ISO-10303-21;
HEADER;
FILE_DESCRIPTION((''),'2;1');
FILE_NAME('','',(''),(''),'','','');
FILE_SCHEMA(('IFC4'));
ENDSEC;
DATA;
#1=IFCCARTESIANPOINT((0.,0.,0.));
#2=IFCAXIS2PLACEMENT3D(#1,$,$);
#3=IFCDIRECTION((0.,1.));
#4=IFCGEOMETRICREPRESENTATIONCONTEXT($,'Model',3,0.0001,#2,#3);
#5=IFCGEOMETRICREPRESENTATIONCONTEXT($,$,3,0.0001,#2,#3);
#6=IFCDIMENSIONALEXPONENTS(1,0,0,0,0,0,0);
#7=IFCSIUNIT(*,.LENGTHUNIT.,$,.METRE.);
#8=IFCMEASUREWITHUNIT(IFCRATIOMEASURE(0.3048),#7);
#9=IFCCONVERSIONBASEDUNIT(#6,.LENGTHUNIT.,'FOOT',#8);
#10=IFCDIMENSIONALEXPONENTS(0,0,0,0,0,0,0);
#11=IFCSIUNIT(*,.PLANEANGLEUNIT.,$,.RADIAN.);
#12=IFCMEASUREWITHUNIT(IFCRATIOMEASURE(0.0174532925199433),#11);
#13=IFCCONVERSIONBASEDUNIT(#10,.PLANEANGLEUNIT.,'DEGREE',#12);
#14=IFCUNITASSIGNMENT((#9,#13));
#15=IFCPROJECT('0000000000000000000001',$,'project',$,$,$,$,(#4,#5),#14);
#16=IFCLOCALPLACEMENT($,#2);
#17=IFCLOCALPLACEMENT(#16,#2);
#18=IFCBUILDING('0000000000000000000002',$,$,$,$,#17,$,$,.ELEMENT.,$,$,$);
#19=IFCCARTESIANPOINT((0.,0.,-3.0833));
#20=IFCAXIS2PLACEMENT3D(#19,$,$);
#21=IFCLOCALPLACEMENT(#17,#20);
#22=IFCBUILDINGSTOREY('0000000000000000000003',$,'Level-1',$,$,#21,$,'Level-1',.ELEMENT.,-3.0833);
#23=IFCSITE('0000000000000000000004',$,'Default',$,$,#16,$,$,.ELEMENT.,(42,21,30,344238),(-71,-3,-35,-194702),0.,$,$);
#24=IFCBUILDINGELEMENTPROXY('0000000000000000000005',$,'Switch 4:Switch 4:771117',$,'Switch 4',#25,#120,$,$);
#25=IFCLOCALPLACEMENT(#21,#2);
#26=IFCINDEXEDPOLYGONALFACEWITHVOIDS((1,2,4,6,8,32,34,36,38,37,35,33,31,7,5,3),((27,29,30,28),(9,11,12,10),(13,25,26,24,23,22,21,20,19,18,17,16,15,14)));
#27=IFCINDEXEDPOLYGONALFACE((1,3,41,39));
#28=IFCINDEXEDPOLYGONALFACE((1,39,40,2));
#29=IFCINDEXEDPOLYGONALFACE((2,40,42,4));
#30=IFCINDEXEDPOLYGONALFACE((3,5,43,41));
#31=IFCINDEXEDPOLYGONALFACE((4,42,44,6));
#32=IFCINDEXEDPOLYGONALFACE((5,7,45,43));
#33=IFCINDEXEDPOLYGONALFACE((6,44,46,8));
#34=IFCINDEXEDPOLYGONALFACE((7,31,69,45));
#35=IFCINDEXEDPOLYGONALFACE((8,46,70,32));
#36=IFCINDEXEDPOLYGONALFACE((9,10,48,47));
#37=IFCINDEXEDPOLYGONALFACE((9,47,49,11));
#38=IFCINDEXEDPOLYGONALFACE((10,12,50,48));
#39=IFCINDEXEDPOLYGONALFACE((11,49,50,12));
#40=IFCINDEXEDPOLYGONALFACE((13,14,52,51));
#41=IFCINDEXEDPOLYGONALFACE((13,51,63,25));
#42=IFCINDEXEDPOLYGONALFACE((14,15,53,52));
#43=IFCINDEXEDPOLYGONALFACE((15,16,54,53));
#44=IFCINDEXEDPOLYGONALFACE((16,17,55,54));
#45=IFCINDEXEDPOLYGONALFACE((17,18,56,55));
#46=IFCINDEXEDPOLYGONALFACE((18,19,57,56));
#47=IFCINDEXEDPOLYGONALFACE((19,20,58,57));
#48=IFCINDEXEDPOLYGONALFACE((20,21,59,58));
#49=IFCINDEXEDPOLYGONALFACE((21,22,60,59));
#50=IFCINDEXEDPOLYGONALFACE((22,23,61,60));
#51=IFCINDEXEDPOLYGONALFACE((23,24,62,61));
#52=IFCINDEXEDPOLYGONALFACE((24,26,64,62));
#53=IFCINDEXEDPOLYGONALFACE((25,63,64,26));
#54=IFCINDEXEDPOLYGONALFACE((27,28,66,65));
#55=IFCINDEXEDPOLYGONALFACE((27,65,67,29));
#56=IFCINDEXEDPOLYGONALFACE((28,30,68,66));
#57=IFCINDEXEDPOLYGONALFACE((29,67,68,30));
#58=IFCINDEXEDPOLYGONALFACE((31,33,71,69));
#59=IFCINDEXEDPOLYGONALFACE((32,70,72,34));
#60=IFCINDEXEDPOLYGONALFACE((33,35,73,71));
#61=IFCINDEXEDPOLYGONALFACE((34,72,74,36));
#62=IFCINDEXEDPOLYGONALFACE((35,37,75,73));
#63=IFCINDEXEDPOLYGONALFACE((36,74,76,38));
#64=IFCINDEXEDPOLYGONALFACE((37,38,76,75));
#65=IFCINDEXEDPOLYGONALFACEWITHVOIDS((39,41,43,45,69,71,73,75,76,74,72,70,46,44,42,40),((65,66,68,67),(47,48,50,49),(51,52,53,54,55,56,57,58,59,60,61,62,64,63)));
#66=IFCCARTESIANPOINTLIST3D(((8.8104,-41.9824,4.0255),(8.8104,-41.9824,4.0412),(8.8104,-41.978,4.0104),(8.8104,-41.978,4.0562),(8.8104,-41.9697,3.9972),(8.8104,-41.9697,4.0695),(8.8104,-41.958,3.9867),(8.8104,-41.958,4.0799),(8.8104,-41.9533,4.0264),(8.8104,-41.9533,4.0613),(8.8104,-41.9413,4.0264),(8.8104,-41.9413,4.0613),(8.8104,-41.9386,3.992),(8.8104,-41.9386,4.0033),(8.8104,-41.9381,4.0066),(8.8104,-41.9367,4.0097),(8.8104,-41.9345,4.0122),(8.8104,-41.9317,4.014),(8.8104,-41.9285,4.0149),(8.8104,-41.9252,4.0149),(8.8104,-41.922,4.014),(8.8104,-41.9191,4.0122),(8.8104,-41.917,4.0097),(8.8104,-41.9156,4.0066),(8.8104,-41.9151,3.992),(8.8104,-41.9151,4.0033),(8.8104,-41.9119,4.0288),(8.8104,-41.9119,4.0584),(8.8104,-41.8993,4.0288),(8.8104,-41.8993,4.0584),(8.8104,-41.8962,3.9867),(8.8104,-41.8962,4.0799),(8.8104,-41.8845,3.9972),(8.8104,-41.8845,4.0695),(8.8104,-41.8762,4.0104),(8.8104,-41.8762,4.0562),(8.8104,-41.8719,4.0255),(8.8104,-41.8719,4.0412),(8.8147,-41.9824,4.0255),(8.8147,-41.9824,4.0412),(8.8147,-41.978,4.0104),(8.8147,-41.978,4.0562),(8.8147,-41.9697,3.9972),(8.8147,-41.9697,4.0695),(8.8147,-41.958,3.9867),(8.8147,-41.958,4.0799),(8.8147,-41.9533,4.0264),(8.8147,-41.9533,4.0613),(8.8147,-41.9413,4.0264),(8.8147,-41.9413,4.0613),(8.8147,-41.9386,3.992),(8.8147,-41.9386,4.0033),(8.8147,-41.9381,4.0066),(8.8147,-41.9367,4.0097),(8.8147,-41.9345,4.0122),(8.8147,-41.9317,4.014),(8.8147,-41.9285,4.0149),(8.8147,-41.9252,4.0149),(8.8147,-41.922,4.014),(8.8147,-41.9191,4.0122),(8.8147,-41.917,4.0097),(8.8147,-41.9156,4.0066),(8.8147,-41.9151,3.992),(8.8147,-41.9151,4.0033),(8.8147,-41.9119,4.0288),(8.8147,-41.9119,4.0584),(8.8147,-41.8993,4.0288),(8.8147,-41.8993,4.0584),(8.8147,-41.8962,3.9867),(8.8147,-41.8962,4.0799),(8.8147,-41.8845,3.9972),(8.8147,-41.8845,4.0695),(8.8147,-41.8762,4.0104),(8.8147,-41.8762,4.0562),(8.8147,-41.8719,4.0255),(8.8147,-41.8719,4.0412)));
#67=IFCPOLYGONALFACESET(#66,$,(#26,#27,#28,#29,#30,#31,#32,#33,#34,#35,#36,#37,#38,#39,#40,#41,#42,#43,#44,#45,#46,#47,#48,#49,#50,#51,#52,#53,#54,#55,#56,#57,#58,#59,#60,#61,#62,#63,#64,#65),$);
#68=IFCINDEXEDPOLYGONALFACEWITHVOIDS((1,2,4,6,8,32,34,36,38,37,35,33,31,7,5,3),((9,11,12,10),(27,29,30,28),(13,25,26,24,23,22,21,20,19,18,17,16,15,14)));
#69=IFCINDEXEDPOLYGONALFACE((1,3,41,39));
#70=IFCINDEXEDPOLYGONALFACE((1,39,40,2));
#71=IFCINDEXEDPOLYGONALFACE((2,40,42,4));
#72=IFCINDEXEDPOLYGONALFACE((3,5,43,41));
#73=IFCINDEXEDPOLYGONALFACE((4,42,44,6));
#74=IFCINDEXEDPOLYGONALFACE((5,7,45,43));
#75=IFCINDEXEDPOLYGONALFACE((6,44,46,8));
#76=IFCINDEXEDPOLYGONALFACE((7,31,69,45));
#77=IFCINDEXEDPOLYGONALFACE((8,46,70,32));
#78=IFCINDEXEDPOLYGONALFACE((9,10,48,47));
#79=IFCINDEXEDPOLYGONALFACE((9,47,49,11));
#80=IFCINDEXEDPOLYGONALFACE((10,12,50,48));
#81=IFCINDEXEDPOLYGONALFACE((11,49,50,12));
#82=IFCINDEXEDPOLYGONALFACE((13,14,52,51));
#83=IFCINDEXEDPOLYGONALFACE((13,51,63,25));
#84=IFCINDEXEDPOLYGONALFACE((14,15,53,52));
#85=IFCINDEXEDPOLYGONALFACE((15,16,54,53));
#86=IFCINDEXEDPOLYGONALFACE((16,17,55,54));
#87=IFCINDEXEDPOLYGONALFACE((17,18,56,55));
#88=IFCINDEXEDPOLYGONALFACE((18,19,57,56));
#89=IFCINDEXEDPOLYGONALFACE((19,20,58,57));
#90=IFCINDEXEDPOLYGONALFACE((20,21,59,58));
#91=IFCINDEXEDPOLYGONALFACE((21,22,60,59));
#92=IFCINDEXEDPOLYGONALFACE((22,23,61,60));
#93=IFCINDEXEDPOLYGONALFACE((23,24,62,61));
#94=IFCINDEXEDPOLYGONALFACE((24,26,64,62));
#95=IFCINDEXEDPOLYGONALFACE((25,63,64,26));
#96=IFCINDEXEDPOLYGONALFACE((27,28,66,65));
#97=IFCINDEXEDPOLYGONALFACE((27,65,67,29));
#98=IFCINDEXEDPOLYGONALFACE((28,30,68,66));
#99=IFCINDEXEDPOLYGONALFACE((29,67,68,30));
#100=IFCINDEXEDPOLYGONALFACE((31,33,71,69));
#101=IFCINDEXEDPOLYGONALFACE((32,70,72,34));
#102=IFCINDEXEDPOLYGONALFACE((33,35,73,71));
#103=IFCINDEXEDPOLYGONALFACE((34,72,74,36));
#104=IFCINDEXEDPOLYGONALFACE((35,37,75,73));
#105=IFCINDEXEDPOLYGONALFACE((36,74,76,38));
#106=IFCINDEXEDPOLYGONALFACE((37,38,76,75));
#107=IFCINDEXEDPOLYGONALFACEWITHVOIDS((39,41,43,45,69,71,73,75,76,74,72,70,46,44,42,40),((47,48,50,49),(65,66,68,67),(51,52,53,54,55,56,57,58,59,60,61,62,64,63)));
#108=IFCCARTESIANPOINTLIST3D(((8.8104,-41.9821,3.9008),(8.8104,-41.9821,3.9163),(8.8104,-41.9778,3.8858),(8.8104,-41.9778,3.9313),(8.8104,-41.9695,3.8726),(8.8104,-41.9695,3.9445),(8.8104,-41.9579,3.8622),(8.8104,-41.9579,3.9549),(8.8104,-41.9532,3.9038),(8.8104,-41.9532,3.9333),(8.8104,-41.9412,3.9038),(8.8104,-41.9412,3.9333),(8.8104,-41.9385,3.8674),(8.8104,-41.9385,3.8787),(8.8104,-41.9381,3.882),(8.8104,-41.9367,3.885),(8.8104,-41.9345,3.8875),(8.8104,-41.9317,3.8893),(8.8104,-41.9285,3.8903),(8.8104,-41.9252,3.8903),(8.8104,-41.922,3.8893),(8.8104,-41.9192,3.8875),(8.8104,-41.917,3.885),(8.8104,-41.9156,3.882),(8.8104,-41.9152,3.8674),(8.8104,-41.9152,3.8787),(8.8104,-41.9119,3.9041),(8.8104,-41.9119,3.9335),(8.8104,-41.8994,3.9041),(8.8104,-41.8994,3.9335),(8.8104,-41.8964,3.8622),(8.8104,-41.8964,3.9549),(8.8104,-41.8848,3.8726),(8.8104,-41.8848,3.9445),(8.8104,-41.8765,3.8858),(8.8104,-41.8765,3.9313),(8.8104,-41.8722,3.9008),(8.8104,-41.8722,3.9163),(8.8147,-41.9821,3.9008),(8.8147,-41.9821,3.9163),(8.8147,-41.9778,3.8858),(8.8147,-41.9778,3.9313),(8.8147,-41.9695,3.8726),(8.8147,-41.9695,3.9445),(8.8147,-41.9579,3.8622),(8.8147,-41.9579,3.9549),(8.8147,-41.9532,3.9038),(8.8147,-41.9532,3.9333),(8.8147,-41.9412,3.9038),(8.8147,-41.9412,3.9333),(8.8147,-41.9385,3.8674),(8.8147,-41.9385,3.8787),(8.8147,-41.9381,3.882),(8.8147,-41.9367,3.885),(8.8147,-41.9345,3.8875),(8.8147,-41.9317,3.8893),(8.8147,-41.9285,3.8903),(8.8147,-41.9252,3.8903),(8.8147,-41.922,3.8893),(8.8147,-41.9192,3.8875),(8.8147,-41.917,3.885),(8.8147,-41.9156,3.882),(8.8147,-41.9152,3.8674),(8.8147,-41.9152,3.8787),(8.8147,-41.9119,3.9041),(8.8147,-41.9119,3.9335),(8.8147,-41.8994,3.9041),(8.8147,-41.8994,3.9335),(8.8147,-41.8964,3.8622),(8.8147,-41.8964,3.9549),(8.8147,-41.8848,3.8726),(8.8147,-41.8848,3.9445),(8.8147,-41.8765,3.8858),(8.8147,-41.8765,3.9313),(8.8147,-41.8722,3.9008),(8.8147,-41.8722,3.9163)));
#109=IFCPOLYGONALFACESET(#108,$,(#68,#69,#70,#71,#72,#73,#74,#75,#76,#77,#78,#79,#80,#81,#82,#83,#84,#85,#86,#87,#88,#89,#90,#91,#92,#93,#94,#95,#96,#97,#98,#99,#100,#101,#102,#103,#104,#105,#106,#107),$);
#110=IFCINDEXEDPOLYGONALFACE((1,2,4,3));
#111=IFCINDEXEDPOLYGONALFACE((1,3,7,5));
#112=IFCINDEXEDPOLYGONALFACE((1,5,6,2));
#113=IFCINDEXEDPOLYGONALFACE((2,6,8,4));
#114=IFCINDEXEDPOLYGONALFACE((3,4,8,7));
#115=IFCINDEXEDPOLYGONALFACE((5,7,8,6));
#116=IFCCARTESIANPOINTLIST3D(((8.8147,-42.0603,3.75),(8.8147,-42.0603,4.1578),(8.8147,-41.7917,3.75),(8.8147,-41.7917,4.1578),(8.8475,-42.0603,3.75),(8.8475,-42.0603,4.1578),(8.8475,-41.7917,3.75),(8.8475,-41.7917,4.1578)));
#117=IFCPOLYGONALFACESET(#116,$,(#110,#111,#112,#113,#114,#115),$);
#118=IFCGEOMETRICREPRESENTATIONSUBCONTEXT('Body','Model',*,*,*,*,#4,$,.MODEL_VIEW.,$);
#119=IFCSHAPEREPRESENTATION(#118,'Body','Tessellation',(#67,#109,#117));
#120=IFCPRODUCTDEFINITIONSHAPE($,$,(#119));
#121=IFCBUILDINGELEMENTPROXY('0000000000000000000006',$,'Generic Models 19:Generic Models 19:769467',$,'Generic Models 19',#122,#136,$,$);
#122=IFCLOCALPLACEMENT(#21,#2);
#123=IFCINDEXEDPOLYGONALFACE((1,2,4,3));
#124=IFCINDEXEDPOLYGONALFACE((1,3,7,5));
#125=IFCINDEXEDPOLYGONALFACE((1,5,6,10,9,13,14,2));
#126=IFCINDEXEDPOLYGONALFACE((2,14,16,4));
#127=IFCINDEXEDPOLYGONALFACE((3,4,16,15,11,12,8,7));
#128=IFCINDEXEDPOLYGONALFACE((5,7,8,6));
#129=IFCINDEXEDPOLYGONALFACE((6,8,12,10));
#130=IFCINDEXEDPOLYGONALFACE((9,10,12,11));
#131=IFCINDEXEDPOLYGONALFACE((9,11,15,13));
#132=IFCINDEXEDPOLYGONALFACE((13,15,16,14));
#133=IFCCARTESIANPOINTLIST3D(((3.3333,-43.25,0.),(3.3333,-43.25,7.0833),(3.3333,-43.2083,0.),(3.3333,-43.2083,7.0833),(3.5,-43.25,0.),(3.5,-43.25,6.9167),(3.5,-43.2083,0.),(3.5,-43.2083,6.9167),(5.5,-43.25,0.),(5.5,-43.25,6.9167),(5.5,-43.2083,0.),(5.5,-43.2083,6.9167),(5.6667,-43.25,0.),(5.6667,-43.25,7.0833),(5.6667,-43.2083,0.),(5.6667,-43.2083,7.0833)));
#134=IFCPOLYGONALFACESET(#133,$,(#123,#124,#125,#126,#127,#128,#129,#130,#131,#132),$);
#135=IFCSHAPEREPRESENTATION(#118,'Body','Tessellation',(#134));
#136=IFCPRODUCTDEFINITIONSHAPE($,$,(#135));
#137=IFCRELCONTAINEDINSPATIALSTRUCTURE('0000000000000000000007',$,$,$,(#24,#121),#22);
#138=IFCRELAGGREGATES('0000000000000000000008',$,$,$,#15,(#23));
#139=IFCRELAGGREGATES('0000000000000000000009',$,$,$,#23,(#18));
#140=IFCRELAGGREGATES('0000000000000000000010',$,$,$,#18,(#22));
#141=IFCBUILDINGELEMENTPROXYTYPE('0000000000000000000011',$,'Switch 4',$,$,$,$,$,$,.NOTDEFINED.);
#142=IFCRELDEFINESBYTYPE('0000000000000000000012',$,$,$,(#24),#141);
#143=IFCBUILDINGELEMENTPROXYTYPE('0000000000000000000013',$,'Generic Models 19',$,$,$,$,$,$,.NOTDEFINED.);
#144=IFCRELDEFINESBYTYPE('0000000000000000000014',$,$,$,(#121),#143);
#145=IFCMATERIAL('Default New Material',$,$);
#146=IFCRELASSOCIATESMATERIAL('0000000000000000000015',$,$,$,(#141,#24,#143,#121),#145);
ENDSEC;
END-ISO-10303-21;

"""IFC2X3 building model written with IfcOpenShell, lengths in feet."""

from ifc_helpers import new_model, entity, si_unit, converted_unit, direction, frame, frame_2d, origin, origin_2d_with_axis, place, context, subcontext, project, spatial, polyline, circle_curve, parameter, trimmed, segment, composite_curve, rectangle, outline, extrude, source, transform, mapped, material, type_object, type_shapes, element, save


model = new_model("IFC2X3")

# Units and contexts
model_context = context("Model", 3, precision=0.0001, world=origin(), true_north=direction((0.0, 1.0)))
context_of_model = context(None, 3, precision=0.0001, world=origin(), true_north=direction((0.0, 1.0)))
body_context = subcontext(model_context, "Body", "Model", "MODEL_VIEW")
ifc_project = project(units=[converted_unit("LENGTHUNIT", "FOOT", entity("IfcRatioMeasure", 0.3048), si_unit("LENGTHUNIT", "METRE"), dimensions=[1, 0, 0, 0, 0, 0, 0]), converted_unit("PLANEANGLEUNIT", "DEGREE", entity("IfcRatioMeasure", 0.0174532925199433), si_unit("PLANEANGLEUNIT", "RADIAN"), dimensions=[0, 0, 0, 0, 0, 0, 0])], contexts=[model_context, context_of_model])

# Site, building, storey
site_placement = place(None, origin())
site = spatial("IfcSite", under=ifc_project, at=site_placement, Name="Default", CompositionType="ELEMENT", RefLatitude=(42, 21, 30, 344238), RefLongitude=(-71, -3, -35, -194702), RefElevation=0.0)
building_placement = place(site_placement, origin())
building = spatial("IfcBuilding", under=site, at=building_placement, CompositionType="ELEMENT")
storey_placement = place(building_placement, frame((0.0, 0.0, -3.0833)))
storey = spatial("IfcBuildingStorey", under=building, at=storey_placement, Name="Level-1", LongName="Level-1", CompositionType="ELEMENT", Elevation=-3.0833)

# Shared definitions
ifc_material = material(Name="Default New Material")

# Building element proxies
building_element_proxy_type_1 = type_object("IfcBuildingElementProxyType", Name="Switch 4", PredefinedType="NOTDEFINED", material=ifc_material)
shared_shape_1 = source(origin(), body_context, "Body", "SweptSolid", [
    extrude(outline(composite_curve([segment(polyline([(-0.0309, -0.0466), (0.0309, -0.0466)]), True, "CONTINUOUS"), segment(trimmed(circle_curve(frame_2d((-0.0003, 0.0), x_axis=(-1.0, 0.0)), 0.0561), [parameter(123.794741)], [parameter(236.205259)], True, "PARAMETER"), True, "CONTINUOUS"), segment(polyline([(0.0309, 0.0466), (-0.0309, 0.0466)]), True, "CONTINUOUS"), segment(trimmed(circle_curve(frame_2d((0.0003, 0.0), x_axis=(1.0, 0.0)), 0.0561), [parameter(123.794741)], [parameter(236.205259)], True, "PARAMETER"), True, "CONTINUOUS")], self_intersect=False), holes=[polyline([(0.0142, 0.0279), (0.0262, 0.0279), (0.0262, -0.0069), (0.0142, -0.0069), (0.0142, 0.0279)]), polyline([(-0.0153, 0.025), (-0.0153, -0.0045), (-0.0278, -0.0045), (-0.0278, 0.025), (-0.0153, 0.025)]), composite_curve([segment(polyline([(-0.012, -0.0413), (-0.012, -0.03)]), True, "CONTINUOUS"), segment(trimmed(circle_curve(frame_2d((-0.0003, -0.03), x_axis=(-1.0, 0.0)), 0.0117), [parameter(180.0)], [parameter(0.0)], True, "PARAMETER"), False, "CONTINUOUS"), segment(polyline([(0.0115, -0.03), (0.0115, -0.0413)]), True, "CONTINUOUS"), segment(polyline([(0.0115, -0.0413), (-0.012, -0.0413)]), True, "CONTINUOUS")], self_intersect=False)]), frame((-0.0011, 0.0328, 0.2833), z_axis=(0.0, 1.0, 0.0), x_axis=(-1.0, 0.0, 0.0)), (0.0, 0.0, 1.0), 0.0042),
    extrude(outline(composite_curve([segment(polyline([(-0.0308, -0.0464), (0.0308, -0.0464)]), True, "CONTINUOUS"), segment(trimmed(circle_curve(frame_2d((-0.0003, 0.0), x_axis=(-1.0, 0.0)), 0.0558), [parameter(123.794741)], [parameter(236.205259)], True, "PARAMETER"), True, "CONTINUOUS"), segment(polyline([(0.0308, 0.0464), (-0.0308, 0.0464)]), True, "CONTINUOUS"), segment(trimmed(circle_curve(frame_2d((0.0003, 0.0), x_axis=(1.0, 0.0)), 0.0558), [parameter(123.794741)], [parameter(236.205259)], True, "PARAMETER"), True, "CONTINUOUS")], self_intersect=False), holes=[polyline([(0.0141, 0.0247), (0.026, 0.0247), (0.026, -0.0047), (0.0141, -0.0047), (0.0141, 0.0247)]), polyline([(-0.0152, 0.0249), (-0.0152, -0.0045), (-0.0277, -0.0045), (-0.0277, 0.0249), (-0.0152, 0.0249)]), composite_curve([segment(polyline([(-0.012, -0.0411), (-0.012, -0.0299)]), True, "CONTINUOUS"), segment(trimmed(circle_curve(frame_2d((-0.0003, -0.0299), x_axis=(-1.0, 0.0)), 0.0117), [parameter(180.0)], [parameter(0.0)], True, "PARAMETER"), False, "CONTINUOUS"), segment(polyline([(0.0114, -0.0299), (0.0114, -0.0411)]), True, "CONTINUOUS"), segment(polyline([(0.0114, -0.0411), (-0.012, -0.0411)]), True, "CONTINUOUS")], self_intersect=False)]), frame((-0.0011, 0.0328, 0.1586), z_axis=(0.0, 1.0, 0.0), x_axis=(-1.0, 0.0, 0.0)), (0.0, 0.0, 1.0), 0.0042),
    extrude(rectangle(XDim=0.0328, YDim=0.2687, at=origin_2d_with_axis()), frame((0.0, 0.0164, 0.0), z_axis=(0.0, 0.0, 1.0), x_axis=(0.0, -1.0, 0.0)), (0.0, 0.0, 1.0), 0.4078),
])
type_shapes(building_element_proxy_type_1, [shared_shape_1])
for number, where, z_axis, x_axis, name in (
    (1, (8.8475, -41.926, 3.75), (0.0, 0.0, 1.0), (0.0, 1.0, 0.0), "Switch 4:Switch 4:771117"),
):
    element("IfcBuildingElementProxy", number, at=place(storey_placement, frame(where, z_axis=z_axis, x_axis=x_axis)), inside=storey, type_object=building_element_proxy_type_1, material=ifc_material, Name=name, ObjectType="Switch 4", context=body_context, shape_type="MappedRepresentation", body=[
        mapped(shared_shape_1, transform((0.0, 0.0, 0.0), scale=1.0)),
    ])
building_element_proxy_type_2 = type_object("IfcBuildingElementProxyType", Name="Generic Models 19", PredefinedType="NOTDEFINED", material=ifc_material)
shared_shape_2 = source(origin(), body_context, "Body", "SweptSolid", [
    extrude(outline(polyline([(-3.5, -1.0), (-3.5, -1.1667), (3.5833, -1.1667), (3.5833, 1.1667), (-3.5, 1.1667), (-3.5, 1.0), (3.4167, 1.0), (3.4167, -1.0), (-3.5, -1.0)])), frame((1.1667, 0.0, 3.5), z_axis=(0.0, -1.0, 0.0), x_axis=(0.0, 0.0, 1.0)), (0.0, 0.0, -1.0), 0.0417),
])
type_shapes(building_element_proxy_type_2, [shared_shape_2])
proxy_1_placement = place(storey_placement, frame((3.3333, -43.25, 0.0)))
element("IfcBuildingElementProxy", 2, at=proxy_1_placement, inside=storey, type_object=building_element_proxy_type_2, material=ifc_material, Name="Generic Models 19:Generic Models 19:769467", ObjectType="Generic Models 19", context=body_context, shape_type="MappedRepresentation", body=[
    mapped(shared_shape_2, transform((0.0, 0.0, 0.0), scale=1.0)),
])

save(model, "model.ifc")
